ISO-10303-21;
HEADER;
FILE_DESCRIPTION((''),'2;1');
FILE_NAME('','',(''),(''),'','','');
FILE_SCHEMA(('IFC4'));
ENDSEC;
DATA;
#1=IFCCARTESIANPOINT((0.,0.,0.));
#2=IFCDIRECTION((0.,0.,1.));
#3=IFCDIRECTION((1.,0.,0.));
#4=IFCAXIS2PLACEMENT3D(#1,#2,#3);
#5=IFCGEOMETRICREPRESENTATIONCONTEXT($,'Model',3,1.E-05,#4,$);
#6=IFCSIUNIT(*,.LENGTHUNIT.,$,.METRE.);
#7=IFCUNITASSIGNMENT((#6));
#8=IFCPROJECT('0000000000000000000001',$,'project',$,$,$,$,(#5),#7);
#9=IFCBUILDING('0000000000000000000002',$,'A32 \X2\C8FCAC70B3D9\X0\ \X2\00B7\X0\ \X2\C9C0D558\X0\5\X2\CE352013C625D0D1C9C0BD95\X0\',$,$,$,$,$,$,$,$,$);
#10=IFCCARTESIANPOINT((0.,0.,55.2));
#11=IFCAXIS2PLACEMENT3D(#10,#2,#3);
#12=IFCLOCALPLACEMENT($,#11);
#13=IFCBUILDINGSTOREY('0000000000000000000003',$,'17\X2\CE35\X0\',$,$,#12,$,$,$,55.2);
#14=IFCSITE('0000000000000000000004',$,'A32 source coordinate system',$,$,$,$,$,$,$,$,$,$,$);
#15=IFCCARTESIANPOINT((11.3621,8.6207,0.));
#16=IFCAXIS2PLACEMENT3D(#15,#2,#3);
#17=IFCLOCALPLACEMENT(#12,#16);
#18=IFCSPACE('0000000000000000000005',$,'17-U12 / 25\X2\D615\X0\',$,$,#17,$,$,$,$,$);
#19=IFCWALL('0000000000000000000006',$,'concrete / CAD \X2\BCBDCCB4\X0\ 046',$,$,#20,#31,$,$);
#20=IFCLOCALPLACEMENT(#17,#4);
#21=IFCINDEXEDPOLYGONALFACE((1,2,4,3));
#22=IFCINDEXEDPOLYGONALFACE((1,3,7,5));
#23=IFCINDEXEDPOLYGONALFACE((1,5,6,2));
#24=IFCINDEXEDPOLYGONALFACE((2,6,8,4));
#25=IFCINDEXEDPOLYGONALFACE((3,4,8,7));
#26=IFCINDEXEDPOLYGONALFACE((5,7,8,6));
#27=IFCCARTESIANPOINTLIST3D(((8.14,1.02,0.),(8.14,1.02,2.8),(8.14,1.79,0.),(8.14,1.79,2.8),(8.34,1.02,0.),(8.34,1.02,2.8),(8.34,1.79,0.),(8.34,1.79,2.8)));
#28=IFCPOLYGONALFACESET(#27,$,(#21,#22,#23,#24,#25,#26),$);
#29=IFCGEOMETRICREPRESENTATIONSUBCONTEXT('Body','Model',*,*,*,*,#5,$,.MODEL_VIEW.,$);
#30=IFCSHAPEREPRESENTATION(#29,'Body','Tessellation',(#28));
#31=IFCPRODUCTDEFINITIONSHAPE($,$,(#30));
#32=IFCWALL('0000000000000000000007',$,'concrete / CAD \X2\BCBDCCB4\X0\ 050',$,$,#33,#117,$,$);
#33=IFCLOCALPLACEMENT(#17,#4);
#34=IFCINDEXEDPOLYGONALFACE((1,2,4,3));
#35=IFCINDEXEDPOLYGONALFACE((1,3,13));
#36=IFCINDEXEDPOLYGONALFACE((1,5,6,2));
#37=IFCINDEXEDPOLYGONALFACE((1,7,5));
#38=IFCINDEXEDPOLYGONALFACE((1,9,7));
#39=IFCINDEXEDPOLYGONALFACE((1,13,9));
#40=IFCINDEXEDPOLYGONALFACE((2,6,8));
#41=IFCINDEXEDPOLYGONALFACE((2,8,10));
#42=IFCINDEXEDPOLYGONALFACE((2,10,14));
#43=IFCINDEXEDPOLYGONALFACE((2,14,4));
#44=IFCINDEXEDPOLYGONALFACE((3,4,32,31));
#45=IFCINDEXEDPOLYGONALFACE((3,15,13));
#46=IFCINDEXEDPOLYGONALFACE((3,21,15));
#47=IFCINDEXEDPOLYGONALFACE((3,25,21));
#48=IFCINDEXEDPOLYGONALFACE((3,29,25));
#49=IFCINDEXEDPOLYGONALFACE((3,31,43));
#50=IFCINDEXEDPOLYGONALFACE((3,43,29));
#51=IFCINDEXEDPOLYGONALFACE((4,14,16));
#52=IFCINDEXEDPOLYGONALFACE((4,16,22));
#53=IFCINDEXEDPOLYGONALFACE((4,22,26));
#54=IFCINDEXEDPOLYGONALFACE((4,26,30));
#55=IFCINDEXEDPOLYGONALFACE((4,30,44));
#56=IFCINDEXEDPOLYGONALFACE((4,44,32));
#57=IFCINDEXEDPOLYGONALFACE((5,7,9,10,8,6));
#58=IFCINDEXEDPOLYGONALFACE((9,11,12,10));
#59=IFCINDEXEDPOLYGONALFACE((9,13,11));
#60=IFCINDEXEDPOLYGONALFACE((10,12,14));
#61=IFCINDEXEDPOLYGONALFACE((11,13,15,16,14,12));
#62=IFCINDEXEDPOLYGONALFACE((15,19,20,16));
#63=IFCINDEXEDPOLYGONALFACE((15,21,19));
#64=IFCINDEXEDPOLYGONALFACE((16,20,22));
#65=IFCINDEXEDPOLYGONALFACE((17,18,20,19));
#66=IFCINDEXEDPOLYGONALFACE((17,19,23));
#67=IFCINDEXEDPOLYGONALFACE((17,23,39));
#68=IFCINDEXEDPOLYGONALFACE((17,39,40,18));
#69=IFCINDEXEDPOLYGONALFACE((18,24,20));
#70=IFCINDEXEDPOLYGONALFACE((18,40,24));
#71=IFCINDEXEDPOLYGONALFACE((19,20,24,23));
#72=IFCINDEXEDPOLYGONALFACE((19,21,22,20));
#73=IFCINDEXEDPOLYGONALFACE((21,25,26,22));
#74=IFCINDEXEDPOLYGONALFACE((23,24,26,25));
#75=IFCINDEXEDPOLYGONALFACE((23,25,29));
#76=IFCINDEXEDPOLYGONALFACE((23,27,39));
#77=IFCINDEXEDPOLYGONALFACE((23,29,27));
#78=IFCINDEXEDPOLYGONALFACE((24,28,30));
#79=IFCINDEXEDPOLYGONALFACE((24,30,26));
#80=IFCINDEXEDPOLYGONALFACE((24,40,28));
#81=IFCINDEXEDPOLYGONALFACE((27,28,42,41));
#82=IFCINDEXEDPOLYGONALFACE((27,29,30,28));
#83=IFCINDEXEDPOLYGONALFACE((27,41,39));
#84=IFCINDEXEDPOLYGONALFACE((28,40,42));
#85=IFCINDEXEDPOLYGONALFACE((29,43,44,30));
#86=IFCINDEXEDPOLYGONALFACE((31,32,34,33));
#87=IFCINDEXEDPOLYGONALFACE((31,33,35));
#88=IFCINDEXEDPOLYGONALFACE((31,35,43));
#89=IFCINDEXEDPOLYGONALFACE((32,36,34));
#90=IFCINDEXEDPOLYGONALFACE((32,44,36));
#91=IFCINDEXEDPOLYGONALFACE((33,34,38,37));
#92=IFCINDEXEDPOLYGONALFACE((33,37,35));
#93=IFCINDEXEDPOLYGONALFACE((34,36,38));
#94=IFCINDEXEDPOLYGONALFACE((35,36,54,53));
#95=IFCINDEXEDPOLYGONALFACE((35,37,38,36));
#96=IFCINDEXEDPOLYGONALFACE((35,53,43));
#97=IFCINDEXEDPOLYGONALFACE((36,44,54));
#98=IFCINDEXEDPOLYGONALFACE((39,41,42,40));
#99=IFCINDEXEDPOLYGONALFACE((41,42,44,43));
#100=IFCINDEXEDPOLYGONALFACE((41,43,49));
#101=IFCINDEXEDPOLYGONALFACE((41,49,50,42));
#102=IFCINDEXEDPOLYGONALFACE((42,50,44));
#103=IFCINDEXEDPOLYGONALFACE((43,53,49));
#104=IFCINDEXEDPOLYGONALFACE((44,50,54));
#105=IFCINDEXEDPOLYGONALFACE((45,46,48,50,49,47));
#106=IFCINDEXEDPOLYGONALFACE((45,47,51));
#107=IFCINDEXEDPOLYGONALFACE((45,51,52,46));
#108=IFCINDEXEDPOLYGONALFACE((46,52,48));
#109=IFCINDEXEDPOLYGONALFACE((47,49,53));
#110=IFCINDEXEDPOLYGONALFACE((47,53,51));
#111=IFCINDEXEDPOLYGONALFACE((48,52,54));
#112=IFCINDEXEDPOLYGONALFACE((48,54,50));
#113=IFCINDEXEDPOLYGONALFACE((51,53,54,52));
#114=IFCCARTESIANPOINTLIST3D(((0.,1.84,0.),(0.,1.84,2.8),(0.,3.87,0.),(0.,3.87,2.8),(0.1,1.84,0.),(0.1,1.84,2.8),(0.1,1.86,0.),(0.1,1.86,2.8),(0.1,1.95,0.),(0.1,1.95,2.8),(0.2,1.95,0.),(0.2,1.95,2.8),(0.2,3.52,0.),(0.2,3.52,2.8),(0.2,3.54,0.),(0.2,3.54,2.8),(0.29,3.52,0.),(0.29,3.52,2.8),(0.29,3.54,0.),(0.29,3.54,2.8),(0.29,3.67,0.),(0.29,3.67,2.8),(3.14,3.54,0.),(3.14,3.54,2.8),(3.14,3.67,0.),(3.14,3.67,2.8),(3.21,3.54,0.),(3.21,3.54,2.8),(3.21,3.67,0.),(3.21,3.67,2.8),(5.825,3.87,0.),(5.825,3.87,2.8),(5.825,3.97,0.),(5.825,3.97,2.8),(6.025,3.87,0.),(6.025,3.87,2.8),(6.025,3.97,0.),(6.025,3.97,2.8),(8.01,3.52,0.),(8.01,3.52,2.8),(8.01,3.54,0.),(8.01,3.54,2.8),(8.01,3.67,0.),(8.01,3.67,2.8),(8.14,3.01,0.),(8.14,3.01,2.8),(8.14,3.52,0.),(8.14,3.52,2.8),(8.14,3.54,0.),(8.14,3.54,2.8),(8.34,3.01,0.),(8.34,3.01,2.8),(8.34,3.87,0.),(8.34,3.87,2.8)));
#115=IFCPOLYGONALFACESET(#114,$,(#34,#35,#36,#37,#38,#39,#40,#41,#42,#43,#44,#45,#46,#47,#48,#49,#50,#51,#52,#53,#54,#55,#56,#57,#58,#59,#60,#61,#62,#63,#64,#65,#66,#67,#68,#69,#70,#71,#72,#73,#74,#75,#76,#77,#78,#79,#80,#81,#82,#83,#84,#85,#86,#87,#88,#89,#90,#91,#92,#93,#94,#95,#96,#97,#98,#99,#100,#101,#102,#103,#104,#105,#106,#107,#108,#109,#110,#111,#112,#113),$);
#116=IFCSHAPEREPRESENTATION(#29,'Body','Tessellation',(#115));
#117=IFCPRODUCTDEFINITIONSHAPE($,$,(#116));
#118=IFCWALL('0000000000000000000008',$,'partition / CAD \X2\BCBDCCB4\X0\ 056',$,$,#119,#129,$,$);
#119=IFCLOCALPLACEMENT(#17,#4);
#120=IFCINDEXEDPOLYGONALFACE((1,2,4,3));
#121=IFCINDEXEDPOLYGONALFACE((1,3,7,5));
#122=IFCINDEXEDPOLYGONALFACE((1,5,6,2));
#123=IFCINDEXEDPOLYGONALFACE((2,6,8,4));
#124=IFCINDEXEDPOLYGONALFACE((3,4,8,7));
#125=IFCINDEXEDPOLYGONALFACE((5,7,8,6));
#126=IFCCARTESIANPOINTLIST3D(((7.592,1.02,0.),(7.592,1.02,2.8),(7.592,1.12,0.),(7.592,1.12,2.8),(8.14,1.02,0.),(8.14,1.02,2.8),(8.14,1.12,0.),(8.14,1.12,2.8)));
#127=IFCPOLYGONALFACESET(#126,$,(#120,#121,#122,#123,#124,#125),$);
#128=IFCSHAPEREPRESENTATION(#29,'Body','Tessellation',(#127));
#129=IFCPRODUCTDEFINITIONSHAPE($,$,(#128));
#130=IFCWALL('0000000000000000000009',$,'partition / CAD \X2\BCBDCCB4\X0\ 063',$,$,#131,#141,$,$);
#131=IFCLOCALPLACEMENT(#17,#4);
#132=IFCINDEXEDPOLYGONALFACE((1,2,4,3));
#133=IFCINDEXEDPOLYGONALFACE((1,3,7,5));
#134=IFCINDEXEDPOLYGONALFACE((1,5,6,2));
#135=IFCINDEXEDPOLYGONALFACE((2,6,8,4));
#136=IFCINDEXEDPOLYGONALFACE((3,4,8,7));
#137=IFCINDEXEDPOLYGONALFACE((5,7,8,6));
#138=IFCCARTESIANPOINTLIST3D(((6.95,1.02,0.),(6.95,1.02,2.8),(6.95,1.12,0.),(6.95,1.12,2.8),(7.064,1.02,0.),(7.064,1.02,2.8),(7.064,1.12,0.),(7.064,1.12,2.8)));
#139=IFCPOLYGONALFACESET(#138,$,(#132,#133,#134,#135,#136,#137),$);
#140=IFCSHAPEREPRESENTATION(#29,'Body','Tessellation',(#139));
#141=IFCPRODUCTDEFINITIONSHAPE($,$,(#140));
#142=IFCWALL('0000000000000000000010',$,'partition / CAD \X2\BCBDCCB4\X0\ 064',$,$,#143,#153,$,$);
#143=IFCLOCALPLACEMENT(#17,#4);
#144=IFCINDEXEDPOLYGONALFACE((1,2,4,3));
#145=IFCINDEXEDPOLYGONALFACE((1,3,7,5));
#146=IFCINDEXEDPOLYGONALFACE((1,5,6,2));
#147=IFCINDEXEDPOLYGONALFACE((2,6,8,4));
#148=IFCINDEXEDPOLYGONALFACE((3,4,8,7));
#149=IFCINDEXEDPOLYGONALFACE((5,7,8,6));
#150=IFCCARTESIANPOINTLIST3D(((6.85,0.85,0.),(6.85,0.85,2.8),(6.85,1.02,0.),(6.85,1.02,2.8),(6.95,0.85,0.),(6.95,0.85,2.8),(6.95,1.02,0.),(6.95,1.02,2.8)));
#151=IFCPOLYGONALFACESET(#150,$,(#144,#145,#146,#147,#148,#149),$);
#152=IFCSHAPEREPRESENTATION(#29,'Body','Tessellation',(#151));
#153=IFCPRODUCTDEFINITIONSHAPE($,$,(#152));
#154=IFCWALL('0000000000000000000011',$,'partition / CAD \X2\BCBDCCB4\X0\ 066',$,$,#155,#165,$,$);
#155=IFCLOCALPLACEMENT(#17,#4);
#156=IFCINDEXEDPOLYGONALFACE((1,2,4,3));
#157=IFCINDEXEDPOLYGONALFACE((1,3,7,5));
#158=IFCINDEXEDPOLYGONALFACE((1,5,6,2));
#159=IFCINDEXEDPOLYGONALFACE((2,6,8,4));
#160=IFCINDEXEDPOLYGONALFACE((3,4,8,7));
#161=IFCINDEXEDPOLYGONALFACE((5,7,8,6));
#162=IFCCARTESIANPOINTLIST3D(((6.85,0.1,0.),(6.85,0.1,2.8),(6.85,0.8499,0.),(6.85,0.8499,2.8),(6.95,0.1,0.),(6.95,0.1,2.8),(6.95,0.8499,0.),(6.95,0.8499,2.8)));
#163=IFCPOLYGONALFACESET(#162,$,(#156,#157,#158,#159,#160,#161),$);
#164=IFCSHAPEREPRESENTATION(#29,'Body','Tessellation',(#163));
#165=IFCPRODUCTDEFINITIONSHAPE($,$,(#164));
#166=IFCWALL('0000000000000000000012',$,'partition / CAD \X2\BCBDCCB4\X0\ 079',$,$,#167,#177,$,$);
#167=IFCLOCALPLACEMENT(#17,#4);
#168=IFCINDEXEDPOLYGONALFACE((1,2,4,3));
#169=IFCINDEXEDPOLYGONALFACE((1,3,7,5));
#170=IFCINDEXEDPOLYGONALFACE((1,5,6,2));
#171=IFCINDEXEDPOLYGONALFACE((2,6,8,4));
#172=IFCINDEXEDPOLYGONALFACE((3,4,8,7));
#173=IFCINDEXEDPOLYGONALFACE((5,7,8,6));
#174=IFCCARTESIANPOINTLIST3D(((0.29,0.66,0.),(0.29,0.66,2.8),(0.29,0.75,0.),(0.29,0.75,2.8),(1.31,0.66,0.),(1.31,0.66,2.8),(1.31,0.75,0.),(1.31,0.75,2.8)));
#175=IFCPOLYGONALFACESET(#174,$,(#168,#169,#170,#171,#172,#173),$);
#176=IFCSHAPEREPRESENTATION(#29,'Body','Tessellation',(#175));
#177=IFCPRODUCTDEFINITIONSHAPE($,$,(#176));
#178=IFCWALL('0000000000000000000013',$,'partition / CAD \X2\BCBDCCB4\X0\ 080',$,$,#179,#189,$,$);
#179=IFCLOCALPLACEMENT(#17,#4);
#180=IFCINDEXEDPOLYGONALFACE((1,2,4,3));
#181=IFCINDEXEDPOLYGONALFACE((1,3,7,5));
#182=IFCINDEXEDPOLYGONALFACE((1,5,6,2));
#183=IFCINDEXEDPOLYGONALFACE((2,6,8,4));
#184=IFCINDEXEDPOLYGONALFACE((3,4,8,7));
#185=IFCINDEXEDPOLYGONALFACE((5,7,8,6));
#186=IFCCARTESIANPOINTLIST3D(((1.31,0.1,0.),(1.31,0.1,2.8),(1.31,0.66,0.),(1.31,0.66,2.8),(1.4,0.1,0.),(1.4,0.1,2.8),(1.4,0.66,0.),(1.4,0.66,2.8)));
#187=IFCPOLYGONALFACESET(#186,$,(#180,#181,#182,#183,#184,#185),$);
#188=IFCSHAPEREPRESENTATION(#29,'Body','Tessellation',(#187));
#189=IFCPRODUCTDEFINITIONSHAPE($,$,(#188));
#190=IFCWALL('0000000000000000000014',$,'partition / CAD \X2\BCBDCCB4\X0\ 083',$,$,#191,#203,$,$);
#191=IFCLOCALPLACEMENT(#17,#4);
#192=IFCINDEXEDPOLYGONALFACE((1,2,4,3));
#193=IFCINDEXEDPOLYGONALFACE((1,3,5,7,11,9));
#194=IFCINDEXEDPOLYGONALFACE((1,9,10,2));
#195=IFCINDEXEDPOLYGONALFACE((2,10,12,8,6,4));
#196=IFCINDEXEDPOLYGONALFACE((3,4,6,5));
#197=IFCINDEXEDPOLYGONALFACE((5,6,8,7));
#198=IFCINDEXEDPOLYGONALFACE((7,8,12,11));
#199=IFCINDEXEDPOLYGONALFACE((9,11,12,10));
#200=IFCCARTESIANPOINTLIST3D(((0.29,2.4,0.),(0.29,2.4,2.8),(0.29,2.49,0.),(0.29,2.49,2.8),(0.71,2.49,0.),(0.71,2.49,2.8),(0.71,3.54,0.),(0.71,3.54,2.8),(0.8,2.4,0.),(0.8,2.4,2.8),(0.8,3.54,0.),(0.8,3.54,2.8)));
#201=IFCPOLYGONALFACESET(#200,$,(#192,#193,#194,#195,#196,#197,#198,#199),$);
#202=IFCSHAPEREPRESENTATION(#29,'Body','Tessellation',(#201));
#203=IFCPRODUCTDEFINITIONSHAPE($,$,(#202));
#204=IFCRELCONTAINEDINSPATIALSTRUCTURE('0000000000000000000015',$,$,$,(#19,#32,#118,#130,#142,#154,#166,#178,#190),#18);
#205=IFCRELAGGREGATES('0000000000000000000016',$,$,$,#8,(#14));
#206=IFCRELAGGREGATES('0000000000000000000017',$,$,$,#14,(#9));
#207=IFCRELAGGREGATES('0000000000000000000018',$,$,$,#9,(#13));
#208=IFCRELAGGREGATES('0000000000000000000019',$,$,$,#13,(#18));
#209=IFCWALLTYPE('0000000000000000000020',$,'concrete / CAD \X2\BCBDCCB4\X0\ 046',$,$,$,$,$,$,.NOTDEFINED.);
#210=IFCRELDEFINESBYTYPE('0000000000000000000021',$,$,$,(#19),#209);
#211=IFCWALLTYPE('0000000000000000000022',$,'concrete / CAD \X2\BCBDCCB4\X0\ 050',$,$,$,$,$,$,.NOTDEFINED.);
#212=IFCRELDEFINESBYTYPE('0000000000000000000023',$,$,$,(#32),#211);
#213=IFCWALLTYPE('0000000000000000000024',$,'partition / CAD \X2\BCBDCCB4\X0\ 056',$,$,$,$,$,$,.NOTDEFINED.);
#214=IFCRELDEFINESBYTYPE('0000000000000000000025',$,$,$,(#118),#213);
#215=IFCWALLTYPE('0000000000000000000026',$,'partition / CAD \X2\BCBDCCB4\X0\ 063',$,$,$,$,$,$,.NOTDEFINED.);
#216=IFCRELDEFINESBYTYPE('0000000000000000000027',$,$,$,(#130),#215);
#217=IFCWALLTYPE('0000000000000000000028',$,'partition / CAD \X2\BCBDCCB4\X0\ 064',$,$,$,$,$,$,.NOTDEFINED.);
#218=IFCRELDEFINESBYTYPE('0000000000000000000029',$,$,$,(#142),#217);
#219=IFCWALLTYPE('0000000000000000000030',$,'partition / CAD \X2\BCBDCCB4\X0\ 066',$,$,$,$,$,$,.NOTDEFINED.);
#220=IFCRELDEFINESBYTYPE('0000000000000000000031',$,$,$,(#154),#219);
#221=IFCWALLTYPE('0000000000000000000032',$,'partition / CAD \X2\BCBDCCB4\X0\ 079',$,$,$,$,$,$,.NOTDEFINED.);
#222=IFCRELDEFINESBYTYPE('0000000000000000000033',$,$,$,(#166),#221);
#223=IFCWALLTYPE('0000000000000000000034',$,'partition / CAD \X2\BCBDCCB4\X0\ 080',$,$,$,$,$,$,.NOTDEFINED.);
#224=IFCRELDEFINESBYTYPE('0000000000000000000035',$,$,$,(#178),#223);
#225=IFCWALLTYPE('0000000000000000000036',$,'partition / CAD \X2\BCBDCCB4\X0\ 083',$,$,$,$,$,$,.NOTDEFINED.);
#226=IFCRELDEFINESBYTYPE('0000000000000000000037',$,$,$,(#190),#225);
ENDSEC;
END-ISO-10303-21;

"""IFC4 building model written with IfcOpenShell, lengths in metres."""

from ifc_helpers import new_model, si_unit, frame, origin, origin_with_axes, place, context, subcontext, project, spatial, polyline, outline, extrude, source, transform, mapped, type_object, type_shapes, element, save


model = new_model("IFC4")

# Units and contexts
model_context = context("Model", 3, precision=1e-05, world=origin_with_axes())
body_context = subcontext(model_context, "Body", "Model", "MODEL_VIEW")
ifc_project = project(units=[si_unit("LENGTHUNIT", "METRE")], contexts=[model_context])

# Site, building, storey, space
site = spatial("IfcSite", under=ifc_project, Name="A32 source coordinate system")
building = spatial("IfcBuilding", under=site, Name="A32 주거동 · 지하5층–옥탑지붕")
storey_placement = place(None, frame((0.0, 0.0, 55.2), z_axis=(0.0, 0.0, 1.0), x_axis=(1.0, 0.0, 0.0)))
storey = spatial("IfcBuildingStorey", under=building, at=storey_placement, Name="17층", Elevation=55.2)
space_1_placement = place(storey_placement, frame((11.3621, 8.6207, 0.0), z_axis=(0.0, 0.0, 1.0), x_axis=(1.0, 0.0, 0.0)))
space_1 = spatial("IfcSpace", under=storey, at=space_1_placement, Name="17-U12 / 25형")

# Walls
wall_type_1 = type_object("IfcWallType", Name="concrete / CAD 벽체 046", PredefinedType="NOTDEFINED")
shared_shape_1 = source(origin(), body_context, "Body", "SweptSolid", [
    extrude(outline(polyline([(8.14, 1.02), (8.14, 1.79), (8.34, 1.79), (8.34, 1.02), (8.14, 1.02)])), origin(), (0.0, 0.0, 1.0), 2.8),
])
type_shapes(wall_type_1, [shared_shape_1])
wall_1_placement = place(space_1_placement, origin_with_axes())
element("IfcWall", 1, at=wall_1_placement, inside=space_1, type_object=wall_type_1, Name="concrete / CAD 벽체 046", context=body_context, shape_type="MappedRepresentation", body=[
    mapped(shared_shape_1, transform((0.0, 0.0, 0.0), scale=1.0)),
])
wall_type_2 = type_object("IfcWallType", Name="concrete / CAD 벽체 050", PredefinedType="NOTDEFINED")
shared_shape_2 = source(origin(), body_context, "Body", "SweptSolid", [
    extrude(outline(polyline([(8.01, 3.52), (0.29, 3.52), (0.29, 3.54), (0.2, 3.54), (0.2, 3.52), (0.2, 1.95), (0.1, 1.95), (0.1, 1.86), (0.1, 1.84), (0.0, 1.84), (0.0, 3.87), (5.825, 3.87), (5.825, 3.97), (6.025, 3.97), (6.025, 3.87), (8.34, 3.87), (8.34, 3.01), (8.14, 3.01), (8.14, 3.52), (8.14, 3.54), (8.01, 3.54), (8.01, 3.52)]), holes=[polyline([(3.14, 3.54), (3.14, 3.67), (0.29, 3.67), (0.29, 3.54), (3.14, 3.54)]), polyline([(8.01, 3.67), (3.21, 3.67), (3.21, 3.54), (8.01, 3.54), (8.01, 3.67)])]), origin(), (0.0, 0.0, 1.0), 2.8),
])
type_shapes(wall_type_2, [shared_shape_2])
wall_2_placement = place(space_1_placement, origin_with_axes())
element("IfcWall", 2, at=wall_2_placement, inside=space_1, type_object=wall_type_2, Name="concrete / CAD 벽체 050", context=body_context, shape_type="MappedRepresentation", body=[
    mapped(shared_shape_2, transform((0.0, 0.0, 0.0), scale=1.0)),
])
wall_type_3 = type_object("IfcWallType", Name="partition / CAD 벽체 056", PredefinedType="NOTDEFINED")
shared_shape_3 = source(origin(), body_context, "Body", "SweptSolid", [
    extrude(outline(polyline([(7.592, 1.12), (8.14, 1.12), (8.14, 1.02), (7.592, 1.02), (7.592, 1.12)])), origin(), (0.0, 0.0, 1.0), 2.8),
])
type_shapes(wall_type_3, [shared_shape_3])
wall_3_placement = place(space_1_placement, origin_with_axes())
element("IfcWall", 3, at=wall_3_placement, inside=space_1, type_object=wall_type_3, Name="partition / CAD 벽체 056", context=body_context, shape_type="MappedRepresentation", body=[
    mapped(shared_shape_3, transform((0.0, 0.0, 0.0), scale=1.0)),
])
wall_type_4 = type_object("IfcWallType", Name="partition / CAD 벽체 063", PredefinedType="NOTDEFINED")
shared_shape_4 = source(origin(), body_context, "Body", "SweptSolid", [
    extrude(outline(polyline([(6.95, 1.12), (7.064, 1.12), (7.064, 1.02), (6.95, 1.02), (6.95, 1.12)])), origin(), (0.0, 0.0, 1.0), 2.8),
])
type_shapes(wall_type_4, [shared_shape_4])
wall_4_placement = place(space_1_placement, origin_with_axes())
element("IfcWall", 4, at=wall_4_placement, inside=space_1, type_object=wall_type_4, Name="partition / CAD 벽체 063", context=body_context, shape_type="MappedRepresentation", body=[
    mapped(shared_shape_4, transform((0.0, 0.0, 0.0), scale=1.0)),
])
wall_type_5 = type_object("IfcWallType", Name="partition / CAD 벽체 064", PredefinedType="NOTDEFINED")
shared_shape_5 = source(origin(), body_context, "Body", "SweptSolid", [
    extrude(outline(polyline([(6.95, 0.85), (6.85, 0.85), (6.85, 1.02), (6.95, 1.02), (6.95, 0.85)])), origin(), (0.0, 0.0, 1.0), 2.8),
])
type_shapes(wall_type_5, [shared_shape_5])
wall_5_placement = place(space_1_placement, origin_with_axes())
element("IfcWall", 5, at=wall_5_placement, inside=space_1, type_object=wall_type_5, Name="partition / CAD 벽체 064", context=body_context, shape_type="MappedRepresentation", body=[
    mapped(shared_shape_5, transform((0.0, 0.0, 0.0), scale=1.0)),
])
wall_type_6 = type_object("IfcWallType", Name="partition / CAD 벽체 066", PredefinedType="NOTDEFINED")
shared_shape_6 = source(origin(), body_context, "Body", "SweptSolid", [
    extrude(outline(polyline([(6.85, 0.8499), (6.95, 0.8499), (6.95, 0.1), (6.85, 0.1), (6.85, 0.8499)])), origin(), (0.0, 0.0, 1.0), 2.8),
])
type_shapes(wall_type_6, [shared_shape_6])
wall_6_placement = place(space_1_placement, origin_with_axes())
element("IfcWall", 6, at=wall_6_placement, inside=space_1, type_object=wall_type_6, Name="partition / CAD 벽체 066", context=body_context, shape_type="MappedRepresentation", body=[
    mapped(shared_shape_6, transform((0.0, 0.0, 0.0), scale=1.0)),
])
wall_type_7 = type_object("IfcWallType", Name="partition / CAD 벽체 079", PredefinedType="NOTDEFINED")
shared_shape_7 = source(origin(), body_context, "Body", "SweptSolid", [
    extrude(outline(polyline([(0.29, 0.75), (1.31, 0.75), (1.31, 0.66), (0.29, 0.66), (0.29, 0.75)])), origin(), (0.0, 0.0, 1.0), 2.8),
])
type_shapes(wall_type_7, [shared_shape_7])
wall_7_placement = place(space_1_placement, origin_with_axes())
element("IfcWall", 7, at=wall_7_placement, inside=space_1, type_object=wall_type_7, Name="partition / CAD 벽체 079", context=body_context, shape_type="MappedRepresentation", body=[
    mapped(shared_shape_7, transform((0.0, 0.0, 0.0), scale=1.0)),
])
wall_type_8 = type_object("IfcWallType", Name="partition / CAD 벽체 080", PredefinedType="NOTDEFINED")
shared_shape_8 = source(origin(), body_context, "Body", "SweptSolid", [
    extrude(outline(polyline([(1.4, 0.66), (1.4, 0.1), (1.31, 0.1), (1.31, 0.66), (1.4, 0.66)])), origin(), (0.0, 0.0, 1.0), 2.8),
])
type_shapes(wall_type_8, [shared_shape_8])
wall_8_placement = place(space_1_placement, origin_with_axes())
element("IfcWall", 8, at=wall_8_placement, inside=space_1, type_object=wall_type_8, Name="partition / CAD 벽체 080", context=body_context, shape_type="MappedRepresentation", body=[
    mapped(shared_shape_8, transform((0.0, 0.0, 0.0), scale=1.0)),
])
wall_type_9 = type_object("IfcWallType", Name="partition / CAD 벽체 083", PredefinedType="NOTDEFINED")
shared_shape_9 = source(origin(), body_context, "Body", "SweptSolid", [
    extrude(outline(polyline([(0.71, 2.49), (0.71, 3.54), (0.8, 3.54), (0.8, 2.4), (0.29, 2.4), (0.29, 2.49), (0.71, 2.49)])), origin(), (0.0, 0.0, 1.0), 2.8),
])
type_shapes(wall_type_9, [shared_shape_9])
wall_9_placement = place(space_1_placement, origin_with_axes())
element("IfcWall", 9, at=wall_9_placement, inside=space_1, type_object=wall_type_9, Name="partition / CAD 벽체 083", context=body_context, shape_type="MappedRepresentation", body=[
    mapped(shared_shape_9, transform((0.0, 0.0, 0.0), scale=1.0)),
])

save(model, "model.ifc")
